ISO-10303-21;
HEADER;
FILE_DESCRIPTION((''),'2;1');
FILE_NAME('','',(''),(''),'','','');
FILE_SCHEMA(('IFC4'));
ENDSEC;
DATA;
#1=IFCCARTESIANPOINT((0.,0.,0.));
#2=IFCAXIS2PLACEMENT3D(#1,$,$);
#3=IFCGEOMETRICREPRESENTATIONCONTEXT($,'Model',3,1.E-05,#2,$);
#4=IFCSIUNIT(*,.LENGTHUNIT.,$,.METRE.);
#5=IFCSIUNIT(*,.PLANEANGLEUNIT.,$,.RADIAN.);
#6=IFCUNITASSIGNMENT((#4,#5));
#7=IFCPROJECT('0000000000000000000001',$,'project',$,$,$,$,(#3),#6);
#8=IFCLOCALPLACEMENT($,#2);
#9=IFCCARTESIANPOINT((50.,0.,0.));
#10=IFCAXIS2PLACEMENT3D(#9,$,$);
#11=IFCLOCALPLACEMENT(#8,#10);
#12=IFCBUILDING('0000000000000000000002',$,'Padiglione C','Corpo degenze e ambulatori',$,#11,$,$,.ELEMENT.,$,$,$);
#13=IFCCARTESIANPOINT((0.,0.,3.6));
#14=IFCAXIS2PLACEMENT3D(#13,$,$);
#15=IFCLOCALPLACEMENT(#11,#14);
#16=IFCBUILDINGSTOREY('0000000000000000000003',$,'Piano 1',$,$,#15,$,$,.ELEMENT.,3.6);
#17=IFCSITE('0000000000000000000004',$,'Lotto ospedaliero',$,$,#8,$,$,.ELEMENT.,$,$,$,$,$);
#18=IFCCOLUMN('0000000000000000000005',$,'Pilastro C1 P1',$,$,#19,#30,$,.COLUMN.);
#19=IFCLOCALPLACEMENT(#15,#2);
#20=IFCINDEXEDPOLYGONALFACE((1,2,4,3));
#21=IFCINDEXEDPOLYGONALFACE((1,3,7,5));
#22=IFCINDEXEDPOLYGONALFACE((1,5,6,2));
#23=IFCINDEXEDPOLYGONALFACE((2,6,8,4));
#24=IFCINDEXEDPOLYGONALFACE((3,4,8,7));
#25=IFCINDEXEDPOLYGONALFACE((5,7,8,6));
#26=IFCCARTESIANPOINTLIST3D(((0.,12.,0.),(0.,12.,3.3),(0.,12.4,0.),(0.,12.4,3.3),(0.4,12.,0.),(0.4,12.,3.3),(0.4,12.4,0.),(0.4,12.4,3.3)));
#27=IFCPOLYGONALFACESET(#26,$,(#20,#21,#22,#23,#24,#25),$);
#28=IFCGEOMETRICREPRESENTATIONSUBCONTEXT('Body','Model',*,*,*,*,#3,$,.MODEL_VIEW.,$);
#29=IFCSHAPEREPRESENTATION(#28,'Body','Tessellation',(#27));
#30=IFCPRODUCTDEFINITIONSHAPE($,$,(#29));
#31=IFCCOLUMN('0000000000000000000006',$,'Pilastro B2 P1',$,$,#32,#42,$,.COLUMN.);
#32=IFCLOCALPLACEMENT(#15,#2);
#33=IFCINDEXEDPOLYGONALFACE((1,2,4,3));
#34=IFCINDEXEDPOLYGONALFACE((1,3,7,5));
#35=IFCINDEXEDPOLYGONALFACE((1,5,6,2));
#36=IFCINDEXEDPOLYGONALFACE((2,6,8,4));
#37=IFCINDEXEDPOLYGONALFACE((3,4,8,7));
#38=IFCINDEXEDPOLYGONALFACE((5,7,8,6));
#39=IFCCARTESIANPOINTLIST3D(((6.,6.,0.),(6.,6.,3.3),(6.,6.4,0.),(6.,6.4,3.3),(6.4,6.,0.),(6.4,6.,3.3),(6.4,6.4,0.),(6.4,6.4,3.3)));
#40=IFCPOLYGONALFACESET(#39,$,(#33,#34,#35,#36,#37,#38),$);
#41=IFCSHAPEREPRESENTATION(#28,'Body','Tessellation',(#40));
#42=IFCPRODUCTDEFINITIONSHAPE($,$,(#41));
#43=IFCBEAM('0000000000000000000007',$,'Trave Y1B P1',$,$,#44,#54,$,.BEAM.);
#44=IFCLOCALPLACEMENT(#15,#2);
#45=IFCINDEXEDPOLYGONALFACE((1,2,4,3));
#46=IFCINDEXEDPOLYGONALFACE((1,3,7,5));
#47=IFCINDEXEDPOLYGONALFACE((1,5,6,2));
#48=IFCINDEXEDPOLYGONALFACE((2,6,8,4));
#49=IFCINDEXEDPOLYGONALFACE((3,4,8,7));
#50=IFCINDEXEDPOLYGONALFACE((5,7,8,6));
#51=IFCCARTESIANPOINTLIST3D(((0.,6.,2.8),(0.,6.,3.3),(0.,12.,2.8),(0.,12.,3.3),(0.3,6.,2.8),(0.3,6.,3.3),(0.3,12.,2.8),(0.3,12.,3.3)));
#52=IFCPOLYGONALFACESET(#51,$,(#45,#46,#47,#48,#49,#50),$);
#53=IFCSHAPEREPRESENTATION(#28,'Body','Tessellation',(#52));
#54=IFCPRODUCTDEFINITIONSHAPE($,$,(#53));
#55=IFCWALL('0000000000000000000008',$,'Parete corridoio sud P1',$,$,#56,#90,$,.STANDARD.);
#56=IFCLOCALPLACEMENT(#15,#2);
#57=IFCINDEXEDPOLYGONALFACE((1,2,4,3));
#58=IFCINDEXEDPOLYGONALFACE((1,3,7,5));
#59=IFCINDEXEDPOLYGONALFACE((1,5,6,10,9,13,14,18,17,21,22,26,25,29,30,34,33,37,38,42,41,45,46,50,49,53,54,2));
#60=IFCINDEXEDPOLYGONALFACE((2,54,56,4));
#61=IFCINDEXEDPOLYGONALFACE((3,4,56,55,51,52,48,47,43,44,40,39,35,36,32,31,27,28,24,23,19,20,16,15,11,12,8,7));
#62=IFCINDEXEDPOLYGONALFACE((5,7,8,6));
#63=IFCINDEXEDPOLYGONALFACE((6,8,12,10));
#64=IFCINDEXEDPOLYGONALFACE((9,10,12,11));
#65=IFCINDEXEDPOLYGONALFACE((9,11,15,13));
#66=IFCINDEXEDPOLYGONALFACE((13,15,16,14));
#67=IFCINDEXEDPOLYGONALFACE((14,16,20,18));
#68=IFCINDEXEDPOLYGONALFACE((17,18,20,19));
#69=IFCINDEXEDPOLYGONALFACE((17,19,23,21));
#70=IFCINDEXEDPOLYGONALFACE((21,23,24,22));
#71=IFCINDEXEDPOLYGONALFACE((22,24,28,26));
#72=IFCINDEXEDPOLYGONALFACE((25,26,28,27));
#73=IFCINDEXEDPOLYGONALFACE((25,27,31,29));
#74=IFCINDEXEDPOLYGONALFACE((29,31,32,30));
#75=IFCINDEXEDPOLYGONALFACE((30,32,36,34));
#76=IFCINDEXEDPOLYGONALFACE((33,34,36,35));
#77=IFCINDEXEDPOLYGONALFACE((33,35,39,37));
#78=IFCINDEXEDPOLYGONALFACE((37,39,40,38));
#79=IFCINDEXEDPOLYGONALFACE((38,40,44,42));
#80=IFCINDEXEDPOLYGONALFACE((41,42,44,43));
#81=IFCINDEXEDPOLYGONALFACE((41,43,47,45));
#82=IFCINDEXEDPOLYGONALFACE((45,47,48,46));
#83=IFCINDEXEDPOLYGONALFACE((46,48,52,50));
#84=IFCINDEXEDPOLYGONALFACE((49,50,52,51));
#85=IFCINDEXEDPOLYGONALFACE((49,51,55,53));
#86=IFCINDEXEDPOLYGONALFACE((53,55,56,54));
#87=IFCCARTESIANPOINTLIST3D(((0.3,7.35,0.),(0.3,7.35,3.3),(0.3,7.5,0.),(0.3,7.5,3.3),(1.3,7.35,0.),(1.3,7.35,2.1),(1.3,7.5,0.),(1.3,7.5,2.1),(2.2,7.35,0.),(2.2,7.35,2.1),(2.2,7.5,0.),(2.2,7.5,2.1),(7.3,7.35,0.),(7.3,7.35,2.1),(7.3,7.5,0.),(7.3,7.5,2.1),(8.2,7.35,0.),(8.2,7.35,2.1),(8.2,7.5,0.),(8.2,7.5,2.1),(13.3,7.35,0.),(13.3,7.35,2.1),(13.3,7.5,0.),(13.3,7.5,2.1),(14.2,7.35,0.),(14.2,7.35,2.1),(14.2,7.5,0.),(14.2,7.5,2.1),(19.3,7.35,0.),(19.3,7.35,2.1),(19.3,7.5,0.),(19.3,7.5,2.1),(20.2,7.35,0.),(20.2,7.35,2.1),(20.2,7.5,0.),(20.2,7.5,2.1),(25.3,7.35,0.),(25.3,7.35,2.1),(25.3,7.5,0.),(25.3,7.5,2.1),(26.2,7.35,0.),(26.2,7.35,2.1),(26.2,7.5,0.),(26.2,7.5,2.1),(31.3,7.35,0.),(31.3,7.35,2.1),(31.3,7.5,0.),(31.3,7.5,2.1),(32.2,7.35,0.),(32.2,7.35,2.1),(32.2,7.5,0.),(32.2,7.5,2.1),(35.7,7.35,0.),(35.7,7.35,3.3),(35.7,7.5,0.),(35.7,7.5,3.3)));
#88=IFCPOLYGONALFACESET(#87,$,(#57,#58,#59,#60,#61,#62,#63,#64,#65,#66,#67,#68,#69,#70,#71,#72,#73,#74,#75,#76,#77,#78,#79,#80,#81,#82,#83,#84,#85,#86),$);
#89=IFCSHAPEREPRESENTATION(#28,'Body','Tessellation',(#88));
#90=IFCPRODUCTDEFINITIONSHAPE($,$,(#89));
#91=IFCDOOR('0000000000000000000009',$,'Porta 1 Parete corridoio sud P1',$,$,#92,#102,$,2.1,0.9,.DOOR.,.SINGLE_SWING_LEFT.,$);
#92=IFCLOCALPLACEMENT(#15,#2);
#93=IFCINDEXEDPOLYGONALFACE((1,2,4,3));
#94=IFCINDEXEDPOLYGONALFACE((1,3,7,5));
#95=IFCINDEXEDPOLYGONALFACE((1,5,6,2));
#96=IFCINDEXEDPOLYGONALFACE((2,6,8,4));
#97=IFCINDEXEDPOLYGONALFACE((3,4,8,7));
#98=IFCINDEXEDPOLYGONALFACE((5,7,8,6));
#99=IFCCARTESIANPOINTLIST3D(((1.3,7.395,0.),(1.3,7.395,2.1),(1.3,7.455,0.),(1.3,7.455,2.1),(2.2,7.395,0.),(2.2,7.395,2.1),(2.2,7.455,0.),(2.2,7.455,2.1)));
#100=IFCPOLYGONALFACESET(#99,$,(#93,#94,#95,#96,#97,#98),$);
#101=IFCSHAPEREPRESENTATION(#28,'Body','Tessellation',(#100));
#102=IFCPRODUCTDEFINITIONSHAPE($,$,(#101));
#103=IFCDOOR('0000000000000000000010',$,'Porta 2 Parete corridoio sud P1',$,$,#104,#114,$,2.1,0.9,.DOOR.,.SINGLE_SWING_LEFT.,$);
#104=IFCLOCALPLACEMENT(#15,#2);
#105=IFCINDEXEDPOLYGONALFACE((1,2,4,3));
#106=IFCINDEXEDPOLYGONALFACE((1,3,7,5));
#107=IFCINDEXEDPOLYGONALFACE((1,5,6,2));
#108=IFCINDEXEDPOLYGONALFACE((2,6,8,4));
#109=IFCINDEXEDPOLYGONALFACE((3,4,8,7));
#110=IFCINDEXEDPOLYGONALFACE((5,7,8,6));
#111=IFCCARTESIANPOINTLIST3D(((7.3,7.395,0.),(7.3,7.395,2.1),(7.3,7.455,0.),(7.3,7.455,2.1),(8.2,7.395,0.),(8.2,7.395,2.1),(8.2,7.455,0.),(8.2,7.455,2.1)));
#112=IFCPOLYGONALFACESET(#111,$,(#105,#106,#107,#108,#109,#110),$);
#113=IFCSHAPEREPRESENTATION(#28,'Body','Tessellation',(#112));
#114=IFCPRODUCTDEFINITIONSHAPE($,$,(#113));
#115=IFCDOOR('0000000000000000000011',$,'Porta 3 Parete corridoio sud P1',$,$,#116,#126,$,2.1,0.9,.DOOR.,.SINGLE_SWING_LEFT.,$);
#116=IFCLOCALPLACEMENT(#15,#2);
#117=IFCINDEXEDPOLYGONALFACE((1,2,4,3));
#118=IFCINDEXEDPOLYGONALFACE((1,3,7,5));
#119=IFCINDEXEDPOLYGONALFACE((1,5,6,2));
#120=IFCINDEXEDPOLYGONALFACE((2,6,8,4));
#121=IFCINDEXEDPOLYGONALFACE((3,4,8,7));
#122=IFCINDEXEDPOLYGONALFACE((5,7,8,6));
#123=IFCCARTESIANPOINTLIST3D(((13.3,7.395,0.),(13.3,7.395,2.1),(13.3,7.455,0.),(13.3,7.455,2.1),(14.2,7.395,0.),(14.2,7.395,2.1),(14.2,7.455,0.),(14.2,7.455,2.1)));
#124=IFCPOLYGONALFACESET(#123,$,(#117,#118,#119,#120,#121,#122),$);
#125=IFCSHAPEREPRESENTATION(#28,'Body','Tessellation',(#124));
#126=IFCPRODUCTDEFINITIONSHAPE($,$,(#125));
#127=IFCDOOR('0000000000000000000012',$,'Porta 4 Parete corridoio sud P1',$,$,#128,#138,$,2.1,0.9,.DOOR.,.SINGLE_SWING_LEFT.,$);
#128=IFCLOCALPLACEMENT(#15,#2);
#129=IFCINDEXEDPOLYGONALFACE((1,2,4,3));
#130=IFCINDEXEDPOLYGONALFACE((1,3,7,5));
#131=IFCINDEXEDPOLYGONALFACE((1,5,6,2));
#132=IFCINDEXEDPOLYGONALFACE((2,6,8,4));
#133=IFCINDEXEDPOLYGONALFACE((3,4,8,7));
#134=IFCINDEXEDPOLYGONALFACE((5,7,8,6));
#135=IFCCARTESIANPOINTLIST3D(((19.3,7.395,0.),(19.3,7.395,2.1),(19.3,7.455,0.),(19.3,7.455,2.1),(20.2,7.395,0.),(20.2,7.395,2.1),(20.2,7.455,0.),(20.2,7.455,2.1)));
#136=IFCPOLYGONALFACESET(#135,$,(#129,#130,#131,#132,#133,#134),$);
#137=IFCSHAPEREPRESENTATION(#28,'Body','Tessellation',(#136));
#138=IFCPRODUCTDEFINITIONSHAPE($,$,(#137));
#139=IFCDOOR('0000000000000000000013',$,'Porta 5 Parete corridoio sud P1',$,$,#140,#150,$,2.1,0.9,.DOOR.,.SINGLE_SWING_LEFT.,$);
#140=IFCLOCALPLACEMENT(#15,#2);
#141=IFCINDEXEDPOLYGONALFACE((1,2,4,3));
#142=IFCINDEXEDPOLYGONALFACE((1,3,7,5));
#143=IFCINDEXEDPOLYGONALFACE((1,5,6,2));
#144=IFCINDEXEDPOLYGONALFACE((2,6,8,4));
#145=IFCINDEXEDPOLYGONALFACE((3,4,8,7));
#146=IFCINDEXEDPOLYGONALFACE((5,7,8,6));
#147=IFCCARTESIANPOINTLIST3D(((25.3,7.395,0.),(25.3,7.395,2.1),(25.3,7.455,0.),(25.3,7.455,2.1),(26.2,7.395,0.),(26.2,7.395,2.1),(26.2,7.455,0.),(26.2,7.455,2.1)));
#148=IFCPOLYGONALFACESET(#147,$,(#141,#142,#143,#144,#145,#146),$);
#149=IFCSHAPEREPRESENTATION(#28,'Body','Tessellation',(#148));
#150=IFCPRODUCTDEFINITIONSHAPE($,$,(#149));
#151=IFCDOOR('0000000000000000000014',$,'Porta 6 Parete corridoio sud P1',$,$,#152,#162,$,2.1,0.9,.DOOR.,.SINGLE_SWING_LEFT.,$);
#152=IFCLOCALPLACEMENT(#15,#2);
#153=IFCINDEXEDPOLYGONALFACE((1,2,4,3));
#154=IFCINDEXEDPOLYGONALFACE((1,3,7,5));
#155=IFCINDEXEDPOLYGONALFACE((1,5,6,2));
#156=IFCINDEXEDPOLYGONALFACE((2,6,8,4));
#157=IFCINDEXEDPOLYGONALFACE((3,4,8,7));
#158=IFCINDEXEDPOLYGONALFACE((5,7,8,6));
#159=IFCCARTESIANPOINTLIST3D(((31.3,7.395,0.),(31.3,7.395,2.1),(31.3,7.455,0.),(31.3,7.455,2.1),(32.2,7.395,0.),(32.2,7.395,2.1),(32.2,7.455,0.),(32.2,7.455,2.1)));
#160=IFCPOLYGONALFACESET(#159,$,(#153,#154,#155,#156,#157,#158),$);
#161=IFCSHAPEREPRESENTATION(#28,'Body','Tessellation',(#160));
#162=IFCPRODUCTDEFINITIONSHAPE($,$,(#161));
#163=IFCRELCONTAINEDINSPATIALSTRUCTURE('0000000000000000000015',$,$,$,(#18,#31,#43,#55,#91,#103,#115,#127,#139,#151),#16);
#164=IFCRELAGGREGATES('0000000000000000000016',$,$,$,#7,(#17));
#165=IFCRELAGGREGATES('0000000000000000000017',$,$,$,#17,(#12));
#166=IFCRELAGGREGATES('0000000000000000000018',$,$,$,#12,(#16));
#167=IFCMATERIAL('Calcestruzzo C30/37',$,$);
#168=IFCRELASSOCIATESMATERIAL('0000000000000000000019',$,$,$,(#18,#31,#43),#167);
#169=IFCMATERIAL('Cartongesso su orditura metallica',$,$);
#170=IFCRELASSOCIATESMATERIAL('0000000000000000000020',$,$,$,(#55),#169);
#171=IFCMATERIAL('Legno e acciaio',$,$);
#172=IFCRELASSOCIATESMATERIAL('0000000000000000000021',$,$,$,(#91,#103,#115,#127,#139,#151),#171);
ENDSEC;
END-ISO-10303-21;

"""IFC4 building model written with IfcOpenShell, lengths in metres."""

from ifc_helpers import new_model, si_unit, frame, frame_2d, origin, place, context, subcontext, project, spatial, rectangle, extrude, material, element, fill, save


model = new_model("IFC4")

# Units and contexts
model_context = context("Model", 3, precision=1e-05, world=origin())
body_context = subcontext(model_context, "Body", "Model", "MODEL_VIEW")
ifc_project = project(units=[si_unit("LENGTHUNIT", "METRE"), si_unit("PLANEANGLEUNIT", "RADIAN")], contexts=[model_context])

# Site, building, storey
site_placement = place(None, origin())
site = spatial("IfcSite", under=ifc_project, at=site_placement, Name="Lotto ospedaliero", CompositionType="ELEMENT")
building_placement = place(site_placement, frame((50.0, 0.0, 0.0)))
building = spatial("IfcBuilding", under=site, at=building_placement, Name="Padiglione C", Description="Corpo degenze e ambulatori", CompositionType="ELEMENT")
storey_placement = place(building_placement, frame((0.0, 0.0, 3.6)))
storey = spatial("IfcBuildingStorey", under=building, at=storey_placement, Name="Piano 1", CompositionType="ELEMENT", Elevation=3.6)

# Columns
ifc_material_1 = material(Name="Calcestruzzo C30/37")
for number, where, name in (
    (1, (0.0, 12.0, 0.0), "Pilastro C1 P1"),
    (2, (6.0, 6.0, 0.0), "Pilastro B2 P1"),
):
    element("IfcColumn", number, at=place(storey_placement, frame(where)), inside=storey, material=ifc_material_1, Name=name, PredefinedType="COLUMN", context=body_context, shape_type="SweptSolid", body=[
        extrude(rectangle(XDim=0.4, YDim=0.4, at=frame_2d((0.2, 0.2))), origin(), (0.0, 0.0, 1.0), 3.3),
    ])

# Beam
beam_placement = place(storey_placement, frame((0.0, 6.0, 2.8)))
element("IfcBeam", 3, at=beam_placement, inside=storey, material=ifc_material_1, Name="Trave Y1B P1", PredefinedType="BEAM", context=body_context, shape_type="SweptSolid", body=[
    extrude(rectangle(XDim=0.3, YDim=6.0, at=frame_2d((0.15, 3.0))), origin(), (0.0, 0.0, 1.0), 0.5),
])

# Wall, openings, doors
ifc_material_2 = material(Name="Cartongesso su orditura metallica")
wall_1_placement = place(storey_placement, frame((0.3, 7.35, 0.0)))
wall_1 = element("IfcWall", 4, at=wall_1_placement, inside=storey, material=ifc_material_2, Name="Parete corridoio sud P1", PredefinedType="STANDARD", context=body_context, shape_type="SweptSolid", body=[
    extrude(rectangle(XDim=35.4, YDim=0.15, at=frame_2d((17.7, 0.075))), origin(), (0.0, 0.0, 1.0), 3.3),
])
opening_1_placement = place(wall_1_placement, frame((1.0, -0.1, 0.0)))
opening_1 = element("IfcOpeningElement", 5, at=opening_1_placement, cuts=wall_1, PredefinedType="OPENING", context=body_context, shape_type="SweptSolid", body=[
    extrude(rectangle(XDim=0.9, YDim=0.35, at=frame_2d((0.45, 0.175))), origin(), (0.0, 0.0, 1.0), 2.1),
])
opening_2_placement = place(wall_1_placement, frame((7.0, -0.1, 0.0)))
opening_2 = element("IfcOpeningElement", 6, at=opening_2_placement, cuts=wall_1, PredefinedType="OPENING", context=body_context, shape_type="SweptSolid", body=[
    extrude(rectangle(XDim=0.9, YDim=0.35, at=frame_2d((0.45, 0.175))), origin(), (0.0, 0.0, 1.0), 2.1),
])
opening_3_placement = place(wall_1_placement, frame((13.0, -0.1, 0.0)))
opening_3 = element("IfcOpeningElement", 7, at=opening_3_placement, cuts=wall_1, PredefinedType="OPENING", context=body_context, shape_type="SweptSolid", body=[
    extrude(rectangle(XDim=0.9, YDim=0.35, at=frame_2d((0.45, 0.175))), origin(), (0.0, 0.0, 1.0), 2.1),
])
opening_4_placement = place(wall_1_placement, frame((19.0, -0.1, 0.0)))
opening_4 = element("IfcOpeningElement", 8, at=opening_4_placement, cuts=wall_1, PredefinedType="OPENING", context=body_context, shape_type="SweptSolid", body=[
    extrude(rectangle(XDim=0.9, YDim=0.35, at=frame_2d((0.45, 0.175))), origin(), (0.0, 0.0, 1.0), 2.1),
])
opening_5_placement = place(wall_1_placement, frame((25.0, -0.1, 0.0)))
opening_5 = element("IfcOpeningElement", 9, at=opening_5_placement, cuts=wall_1, PredefinedType="OPENING", context=body_context, shape_type="SweptSolid", body=[
    extrude(rectangle(XDim=0.9, YDim=0.35, at=frame_2d((0.45, 0.175))), origin(), (0.0, 0.0, 1.0), 2.1),
])
opening_6_placement = place(wall_1_placement, frame((31.0, -0.1, 0.0)))
opening_6 = element("IfcOpeningElement", 10, at=opening_6_placement, cuts=wall_1, PredefinedType="OPENING", context=body_context, shape_type="SweptSolid", body=[
    extrude(rectangle(XDim=0.9, YDim=0.35, at=frame_2d((0.45, 0.175))), origin(), (0.0, 0.0, 1.0), 2.1),
])
ifc_material_3 = material(Name="Legno e acciaio")
door_1_placement = place(wall_1_placement, frame((1.0, 0.045, 0.0)))
door_1 = element("IfcDoor", 11, at=door_1_placement, inside=storey, material=ifc_material_3, Name="Porta 1 Parete corridoio sud P1", OperationType="SINGLE_SWING_LEFT", OverallHeight=2.1, OverallWidth=0.9, PredefinedType="DOOR", context=body_context, shape_type="SweptSolid", body=[
    extrude(rectangle(XDim=0.9, YDim=0.06, at=frame_2d((0.45, 0.03))), origin(), (0.0, 0.0, 1.0), 2.1),
])
fill(opening_1, door_1)
door_2_placement = place(wall_1_placement, frame((7.0, 0.045, 0.0)))
door_2 = element("IfcDoor", 12, at=door_2_placement, inside=storey, material=ifc_material_3, Name="Porta 2 Parete corridoio sud P1", OperationType="SINGLE_SWING_LEFT", OverallHeight=2.1, OverallWidth=0.9, PredefinedType="DOOR", context=body_context, shape_type="SweptSolid", body=[
    extrude(rectangle(XDim=0.9, YDim=0.06, at=frame_2d((0.45, 0.03))), origin(), (0.0, 0.0, 1.0), 2.1),
])
fill(opening_2, door_2)
door_3_placement = place(wall_1_placement, frame((13.0, 0.045, 0.0)))
door_3 = element("IfcDoor", 13, at=door_3_placement, inside=storey, material=ifc_material_3, Name="Porta 3 Parete corridoio sud P1", OperationType="SINGLE_SWING_LEFT", OverallHeight=2.1, OverallWidth=0.9, PredefinedType="DOOR", context=body_context, shape_type="SweptSolid", body=[
    extrude(rectangle(XDim=0.9, YDim=0.06, at=frame_2d((0.45, 0.03))), origin(), (0.0, 0.0, 1.0), 2.1),
])
fill(opening_3, door_3)
door_4_placement = place(wall_1_placement, frame((19.0, 0.045, 0.0)))
door_4 = element("IfcDoor", 14, at=door_4_placement, inside=storey, material=ifc_material_3, Name="Porta 4 Parete corridoio sud P1", OperationType="SINGLE_SWING_LEFT", OverallHeight=2.1, OverallWidth=0.9, PredefinedType="DOOR", context=body_context, shape_type="SweptSolid", body=[
    extrude(rectangle(XDim=0.9, YDim=0.06, at=frame_2d((0.45, 0.03))), origin(), (0.0, 0.0, 1.0), 2.1),
])
fill(opening_4, door_4)
door_5_placement = place(wall_1_placement, frame((25.0, 0.045, 0.0)))
door_5 = element("IfcDoor", 15, at=door_5_placement, inside=storey, material=ifc_material_3, Name="Porta 5 Parete corridoio sud P1", OperationType="SINGLE_SWING_LEFT", OverallHeight=2.1, OverallWidth=0.9, PredefinedType="DOOR", context=body_context, shape_type="SweptSolid", body=[
    extrude(rectangle(XDim=0.9, YDim=0.06, at=frame_2d((0.45, 0.03))), origin(), (0.0, 0.0, 1.0), 2.1),
])
fill(opening_5, door_5)
door_6_placement = place(wall_1_placement, frame((31.0, 0.045, 0.0)))
door_6 = element("IfcDoor", 16, at=door_6_placement, inside=storey, material=ifc_material_3, Name="Porta 6 Parete corridoio sud P1", OperationType="SINGLE_SWING_LEFT", OverallHeight=2.1, OverallWidth=0.9, PredefinedType="DOOR", context=body_context, shape_type="SweptSolid", body=[
    extrude(rectangle(XDim=0.9, YDim=0.06, at=frame_2d((0.45, 0.03))), origin(), (0.0, 0.0, 1.0), 2.1),
])
fill(opening_6, door_6)

save(model, "model.ifc")
